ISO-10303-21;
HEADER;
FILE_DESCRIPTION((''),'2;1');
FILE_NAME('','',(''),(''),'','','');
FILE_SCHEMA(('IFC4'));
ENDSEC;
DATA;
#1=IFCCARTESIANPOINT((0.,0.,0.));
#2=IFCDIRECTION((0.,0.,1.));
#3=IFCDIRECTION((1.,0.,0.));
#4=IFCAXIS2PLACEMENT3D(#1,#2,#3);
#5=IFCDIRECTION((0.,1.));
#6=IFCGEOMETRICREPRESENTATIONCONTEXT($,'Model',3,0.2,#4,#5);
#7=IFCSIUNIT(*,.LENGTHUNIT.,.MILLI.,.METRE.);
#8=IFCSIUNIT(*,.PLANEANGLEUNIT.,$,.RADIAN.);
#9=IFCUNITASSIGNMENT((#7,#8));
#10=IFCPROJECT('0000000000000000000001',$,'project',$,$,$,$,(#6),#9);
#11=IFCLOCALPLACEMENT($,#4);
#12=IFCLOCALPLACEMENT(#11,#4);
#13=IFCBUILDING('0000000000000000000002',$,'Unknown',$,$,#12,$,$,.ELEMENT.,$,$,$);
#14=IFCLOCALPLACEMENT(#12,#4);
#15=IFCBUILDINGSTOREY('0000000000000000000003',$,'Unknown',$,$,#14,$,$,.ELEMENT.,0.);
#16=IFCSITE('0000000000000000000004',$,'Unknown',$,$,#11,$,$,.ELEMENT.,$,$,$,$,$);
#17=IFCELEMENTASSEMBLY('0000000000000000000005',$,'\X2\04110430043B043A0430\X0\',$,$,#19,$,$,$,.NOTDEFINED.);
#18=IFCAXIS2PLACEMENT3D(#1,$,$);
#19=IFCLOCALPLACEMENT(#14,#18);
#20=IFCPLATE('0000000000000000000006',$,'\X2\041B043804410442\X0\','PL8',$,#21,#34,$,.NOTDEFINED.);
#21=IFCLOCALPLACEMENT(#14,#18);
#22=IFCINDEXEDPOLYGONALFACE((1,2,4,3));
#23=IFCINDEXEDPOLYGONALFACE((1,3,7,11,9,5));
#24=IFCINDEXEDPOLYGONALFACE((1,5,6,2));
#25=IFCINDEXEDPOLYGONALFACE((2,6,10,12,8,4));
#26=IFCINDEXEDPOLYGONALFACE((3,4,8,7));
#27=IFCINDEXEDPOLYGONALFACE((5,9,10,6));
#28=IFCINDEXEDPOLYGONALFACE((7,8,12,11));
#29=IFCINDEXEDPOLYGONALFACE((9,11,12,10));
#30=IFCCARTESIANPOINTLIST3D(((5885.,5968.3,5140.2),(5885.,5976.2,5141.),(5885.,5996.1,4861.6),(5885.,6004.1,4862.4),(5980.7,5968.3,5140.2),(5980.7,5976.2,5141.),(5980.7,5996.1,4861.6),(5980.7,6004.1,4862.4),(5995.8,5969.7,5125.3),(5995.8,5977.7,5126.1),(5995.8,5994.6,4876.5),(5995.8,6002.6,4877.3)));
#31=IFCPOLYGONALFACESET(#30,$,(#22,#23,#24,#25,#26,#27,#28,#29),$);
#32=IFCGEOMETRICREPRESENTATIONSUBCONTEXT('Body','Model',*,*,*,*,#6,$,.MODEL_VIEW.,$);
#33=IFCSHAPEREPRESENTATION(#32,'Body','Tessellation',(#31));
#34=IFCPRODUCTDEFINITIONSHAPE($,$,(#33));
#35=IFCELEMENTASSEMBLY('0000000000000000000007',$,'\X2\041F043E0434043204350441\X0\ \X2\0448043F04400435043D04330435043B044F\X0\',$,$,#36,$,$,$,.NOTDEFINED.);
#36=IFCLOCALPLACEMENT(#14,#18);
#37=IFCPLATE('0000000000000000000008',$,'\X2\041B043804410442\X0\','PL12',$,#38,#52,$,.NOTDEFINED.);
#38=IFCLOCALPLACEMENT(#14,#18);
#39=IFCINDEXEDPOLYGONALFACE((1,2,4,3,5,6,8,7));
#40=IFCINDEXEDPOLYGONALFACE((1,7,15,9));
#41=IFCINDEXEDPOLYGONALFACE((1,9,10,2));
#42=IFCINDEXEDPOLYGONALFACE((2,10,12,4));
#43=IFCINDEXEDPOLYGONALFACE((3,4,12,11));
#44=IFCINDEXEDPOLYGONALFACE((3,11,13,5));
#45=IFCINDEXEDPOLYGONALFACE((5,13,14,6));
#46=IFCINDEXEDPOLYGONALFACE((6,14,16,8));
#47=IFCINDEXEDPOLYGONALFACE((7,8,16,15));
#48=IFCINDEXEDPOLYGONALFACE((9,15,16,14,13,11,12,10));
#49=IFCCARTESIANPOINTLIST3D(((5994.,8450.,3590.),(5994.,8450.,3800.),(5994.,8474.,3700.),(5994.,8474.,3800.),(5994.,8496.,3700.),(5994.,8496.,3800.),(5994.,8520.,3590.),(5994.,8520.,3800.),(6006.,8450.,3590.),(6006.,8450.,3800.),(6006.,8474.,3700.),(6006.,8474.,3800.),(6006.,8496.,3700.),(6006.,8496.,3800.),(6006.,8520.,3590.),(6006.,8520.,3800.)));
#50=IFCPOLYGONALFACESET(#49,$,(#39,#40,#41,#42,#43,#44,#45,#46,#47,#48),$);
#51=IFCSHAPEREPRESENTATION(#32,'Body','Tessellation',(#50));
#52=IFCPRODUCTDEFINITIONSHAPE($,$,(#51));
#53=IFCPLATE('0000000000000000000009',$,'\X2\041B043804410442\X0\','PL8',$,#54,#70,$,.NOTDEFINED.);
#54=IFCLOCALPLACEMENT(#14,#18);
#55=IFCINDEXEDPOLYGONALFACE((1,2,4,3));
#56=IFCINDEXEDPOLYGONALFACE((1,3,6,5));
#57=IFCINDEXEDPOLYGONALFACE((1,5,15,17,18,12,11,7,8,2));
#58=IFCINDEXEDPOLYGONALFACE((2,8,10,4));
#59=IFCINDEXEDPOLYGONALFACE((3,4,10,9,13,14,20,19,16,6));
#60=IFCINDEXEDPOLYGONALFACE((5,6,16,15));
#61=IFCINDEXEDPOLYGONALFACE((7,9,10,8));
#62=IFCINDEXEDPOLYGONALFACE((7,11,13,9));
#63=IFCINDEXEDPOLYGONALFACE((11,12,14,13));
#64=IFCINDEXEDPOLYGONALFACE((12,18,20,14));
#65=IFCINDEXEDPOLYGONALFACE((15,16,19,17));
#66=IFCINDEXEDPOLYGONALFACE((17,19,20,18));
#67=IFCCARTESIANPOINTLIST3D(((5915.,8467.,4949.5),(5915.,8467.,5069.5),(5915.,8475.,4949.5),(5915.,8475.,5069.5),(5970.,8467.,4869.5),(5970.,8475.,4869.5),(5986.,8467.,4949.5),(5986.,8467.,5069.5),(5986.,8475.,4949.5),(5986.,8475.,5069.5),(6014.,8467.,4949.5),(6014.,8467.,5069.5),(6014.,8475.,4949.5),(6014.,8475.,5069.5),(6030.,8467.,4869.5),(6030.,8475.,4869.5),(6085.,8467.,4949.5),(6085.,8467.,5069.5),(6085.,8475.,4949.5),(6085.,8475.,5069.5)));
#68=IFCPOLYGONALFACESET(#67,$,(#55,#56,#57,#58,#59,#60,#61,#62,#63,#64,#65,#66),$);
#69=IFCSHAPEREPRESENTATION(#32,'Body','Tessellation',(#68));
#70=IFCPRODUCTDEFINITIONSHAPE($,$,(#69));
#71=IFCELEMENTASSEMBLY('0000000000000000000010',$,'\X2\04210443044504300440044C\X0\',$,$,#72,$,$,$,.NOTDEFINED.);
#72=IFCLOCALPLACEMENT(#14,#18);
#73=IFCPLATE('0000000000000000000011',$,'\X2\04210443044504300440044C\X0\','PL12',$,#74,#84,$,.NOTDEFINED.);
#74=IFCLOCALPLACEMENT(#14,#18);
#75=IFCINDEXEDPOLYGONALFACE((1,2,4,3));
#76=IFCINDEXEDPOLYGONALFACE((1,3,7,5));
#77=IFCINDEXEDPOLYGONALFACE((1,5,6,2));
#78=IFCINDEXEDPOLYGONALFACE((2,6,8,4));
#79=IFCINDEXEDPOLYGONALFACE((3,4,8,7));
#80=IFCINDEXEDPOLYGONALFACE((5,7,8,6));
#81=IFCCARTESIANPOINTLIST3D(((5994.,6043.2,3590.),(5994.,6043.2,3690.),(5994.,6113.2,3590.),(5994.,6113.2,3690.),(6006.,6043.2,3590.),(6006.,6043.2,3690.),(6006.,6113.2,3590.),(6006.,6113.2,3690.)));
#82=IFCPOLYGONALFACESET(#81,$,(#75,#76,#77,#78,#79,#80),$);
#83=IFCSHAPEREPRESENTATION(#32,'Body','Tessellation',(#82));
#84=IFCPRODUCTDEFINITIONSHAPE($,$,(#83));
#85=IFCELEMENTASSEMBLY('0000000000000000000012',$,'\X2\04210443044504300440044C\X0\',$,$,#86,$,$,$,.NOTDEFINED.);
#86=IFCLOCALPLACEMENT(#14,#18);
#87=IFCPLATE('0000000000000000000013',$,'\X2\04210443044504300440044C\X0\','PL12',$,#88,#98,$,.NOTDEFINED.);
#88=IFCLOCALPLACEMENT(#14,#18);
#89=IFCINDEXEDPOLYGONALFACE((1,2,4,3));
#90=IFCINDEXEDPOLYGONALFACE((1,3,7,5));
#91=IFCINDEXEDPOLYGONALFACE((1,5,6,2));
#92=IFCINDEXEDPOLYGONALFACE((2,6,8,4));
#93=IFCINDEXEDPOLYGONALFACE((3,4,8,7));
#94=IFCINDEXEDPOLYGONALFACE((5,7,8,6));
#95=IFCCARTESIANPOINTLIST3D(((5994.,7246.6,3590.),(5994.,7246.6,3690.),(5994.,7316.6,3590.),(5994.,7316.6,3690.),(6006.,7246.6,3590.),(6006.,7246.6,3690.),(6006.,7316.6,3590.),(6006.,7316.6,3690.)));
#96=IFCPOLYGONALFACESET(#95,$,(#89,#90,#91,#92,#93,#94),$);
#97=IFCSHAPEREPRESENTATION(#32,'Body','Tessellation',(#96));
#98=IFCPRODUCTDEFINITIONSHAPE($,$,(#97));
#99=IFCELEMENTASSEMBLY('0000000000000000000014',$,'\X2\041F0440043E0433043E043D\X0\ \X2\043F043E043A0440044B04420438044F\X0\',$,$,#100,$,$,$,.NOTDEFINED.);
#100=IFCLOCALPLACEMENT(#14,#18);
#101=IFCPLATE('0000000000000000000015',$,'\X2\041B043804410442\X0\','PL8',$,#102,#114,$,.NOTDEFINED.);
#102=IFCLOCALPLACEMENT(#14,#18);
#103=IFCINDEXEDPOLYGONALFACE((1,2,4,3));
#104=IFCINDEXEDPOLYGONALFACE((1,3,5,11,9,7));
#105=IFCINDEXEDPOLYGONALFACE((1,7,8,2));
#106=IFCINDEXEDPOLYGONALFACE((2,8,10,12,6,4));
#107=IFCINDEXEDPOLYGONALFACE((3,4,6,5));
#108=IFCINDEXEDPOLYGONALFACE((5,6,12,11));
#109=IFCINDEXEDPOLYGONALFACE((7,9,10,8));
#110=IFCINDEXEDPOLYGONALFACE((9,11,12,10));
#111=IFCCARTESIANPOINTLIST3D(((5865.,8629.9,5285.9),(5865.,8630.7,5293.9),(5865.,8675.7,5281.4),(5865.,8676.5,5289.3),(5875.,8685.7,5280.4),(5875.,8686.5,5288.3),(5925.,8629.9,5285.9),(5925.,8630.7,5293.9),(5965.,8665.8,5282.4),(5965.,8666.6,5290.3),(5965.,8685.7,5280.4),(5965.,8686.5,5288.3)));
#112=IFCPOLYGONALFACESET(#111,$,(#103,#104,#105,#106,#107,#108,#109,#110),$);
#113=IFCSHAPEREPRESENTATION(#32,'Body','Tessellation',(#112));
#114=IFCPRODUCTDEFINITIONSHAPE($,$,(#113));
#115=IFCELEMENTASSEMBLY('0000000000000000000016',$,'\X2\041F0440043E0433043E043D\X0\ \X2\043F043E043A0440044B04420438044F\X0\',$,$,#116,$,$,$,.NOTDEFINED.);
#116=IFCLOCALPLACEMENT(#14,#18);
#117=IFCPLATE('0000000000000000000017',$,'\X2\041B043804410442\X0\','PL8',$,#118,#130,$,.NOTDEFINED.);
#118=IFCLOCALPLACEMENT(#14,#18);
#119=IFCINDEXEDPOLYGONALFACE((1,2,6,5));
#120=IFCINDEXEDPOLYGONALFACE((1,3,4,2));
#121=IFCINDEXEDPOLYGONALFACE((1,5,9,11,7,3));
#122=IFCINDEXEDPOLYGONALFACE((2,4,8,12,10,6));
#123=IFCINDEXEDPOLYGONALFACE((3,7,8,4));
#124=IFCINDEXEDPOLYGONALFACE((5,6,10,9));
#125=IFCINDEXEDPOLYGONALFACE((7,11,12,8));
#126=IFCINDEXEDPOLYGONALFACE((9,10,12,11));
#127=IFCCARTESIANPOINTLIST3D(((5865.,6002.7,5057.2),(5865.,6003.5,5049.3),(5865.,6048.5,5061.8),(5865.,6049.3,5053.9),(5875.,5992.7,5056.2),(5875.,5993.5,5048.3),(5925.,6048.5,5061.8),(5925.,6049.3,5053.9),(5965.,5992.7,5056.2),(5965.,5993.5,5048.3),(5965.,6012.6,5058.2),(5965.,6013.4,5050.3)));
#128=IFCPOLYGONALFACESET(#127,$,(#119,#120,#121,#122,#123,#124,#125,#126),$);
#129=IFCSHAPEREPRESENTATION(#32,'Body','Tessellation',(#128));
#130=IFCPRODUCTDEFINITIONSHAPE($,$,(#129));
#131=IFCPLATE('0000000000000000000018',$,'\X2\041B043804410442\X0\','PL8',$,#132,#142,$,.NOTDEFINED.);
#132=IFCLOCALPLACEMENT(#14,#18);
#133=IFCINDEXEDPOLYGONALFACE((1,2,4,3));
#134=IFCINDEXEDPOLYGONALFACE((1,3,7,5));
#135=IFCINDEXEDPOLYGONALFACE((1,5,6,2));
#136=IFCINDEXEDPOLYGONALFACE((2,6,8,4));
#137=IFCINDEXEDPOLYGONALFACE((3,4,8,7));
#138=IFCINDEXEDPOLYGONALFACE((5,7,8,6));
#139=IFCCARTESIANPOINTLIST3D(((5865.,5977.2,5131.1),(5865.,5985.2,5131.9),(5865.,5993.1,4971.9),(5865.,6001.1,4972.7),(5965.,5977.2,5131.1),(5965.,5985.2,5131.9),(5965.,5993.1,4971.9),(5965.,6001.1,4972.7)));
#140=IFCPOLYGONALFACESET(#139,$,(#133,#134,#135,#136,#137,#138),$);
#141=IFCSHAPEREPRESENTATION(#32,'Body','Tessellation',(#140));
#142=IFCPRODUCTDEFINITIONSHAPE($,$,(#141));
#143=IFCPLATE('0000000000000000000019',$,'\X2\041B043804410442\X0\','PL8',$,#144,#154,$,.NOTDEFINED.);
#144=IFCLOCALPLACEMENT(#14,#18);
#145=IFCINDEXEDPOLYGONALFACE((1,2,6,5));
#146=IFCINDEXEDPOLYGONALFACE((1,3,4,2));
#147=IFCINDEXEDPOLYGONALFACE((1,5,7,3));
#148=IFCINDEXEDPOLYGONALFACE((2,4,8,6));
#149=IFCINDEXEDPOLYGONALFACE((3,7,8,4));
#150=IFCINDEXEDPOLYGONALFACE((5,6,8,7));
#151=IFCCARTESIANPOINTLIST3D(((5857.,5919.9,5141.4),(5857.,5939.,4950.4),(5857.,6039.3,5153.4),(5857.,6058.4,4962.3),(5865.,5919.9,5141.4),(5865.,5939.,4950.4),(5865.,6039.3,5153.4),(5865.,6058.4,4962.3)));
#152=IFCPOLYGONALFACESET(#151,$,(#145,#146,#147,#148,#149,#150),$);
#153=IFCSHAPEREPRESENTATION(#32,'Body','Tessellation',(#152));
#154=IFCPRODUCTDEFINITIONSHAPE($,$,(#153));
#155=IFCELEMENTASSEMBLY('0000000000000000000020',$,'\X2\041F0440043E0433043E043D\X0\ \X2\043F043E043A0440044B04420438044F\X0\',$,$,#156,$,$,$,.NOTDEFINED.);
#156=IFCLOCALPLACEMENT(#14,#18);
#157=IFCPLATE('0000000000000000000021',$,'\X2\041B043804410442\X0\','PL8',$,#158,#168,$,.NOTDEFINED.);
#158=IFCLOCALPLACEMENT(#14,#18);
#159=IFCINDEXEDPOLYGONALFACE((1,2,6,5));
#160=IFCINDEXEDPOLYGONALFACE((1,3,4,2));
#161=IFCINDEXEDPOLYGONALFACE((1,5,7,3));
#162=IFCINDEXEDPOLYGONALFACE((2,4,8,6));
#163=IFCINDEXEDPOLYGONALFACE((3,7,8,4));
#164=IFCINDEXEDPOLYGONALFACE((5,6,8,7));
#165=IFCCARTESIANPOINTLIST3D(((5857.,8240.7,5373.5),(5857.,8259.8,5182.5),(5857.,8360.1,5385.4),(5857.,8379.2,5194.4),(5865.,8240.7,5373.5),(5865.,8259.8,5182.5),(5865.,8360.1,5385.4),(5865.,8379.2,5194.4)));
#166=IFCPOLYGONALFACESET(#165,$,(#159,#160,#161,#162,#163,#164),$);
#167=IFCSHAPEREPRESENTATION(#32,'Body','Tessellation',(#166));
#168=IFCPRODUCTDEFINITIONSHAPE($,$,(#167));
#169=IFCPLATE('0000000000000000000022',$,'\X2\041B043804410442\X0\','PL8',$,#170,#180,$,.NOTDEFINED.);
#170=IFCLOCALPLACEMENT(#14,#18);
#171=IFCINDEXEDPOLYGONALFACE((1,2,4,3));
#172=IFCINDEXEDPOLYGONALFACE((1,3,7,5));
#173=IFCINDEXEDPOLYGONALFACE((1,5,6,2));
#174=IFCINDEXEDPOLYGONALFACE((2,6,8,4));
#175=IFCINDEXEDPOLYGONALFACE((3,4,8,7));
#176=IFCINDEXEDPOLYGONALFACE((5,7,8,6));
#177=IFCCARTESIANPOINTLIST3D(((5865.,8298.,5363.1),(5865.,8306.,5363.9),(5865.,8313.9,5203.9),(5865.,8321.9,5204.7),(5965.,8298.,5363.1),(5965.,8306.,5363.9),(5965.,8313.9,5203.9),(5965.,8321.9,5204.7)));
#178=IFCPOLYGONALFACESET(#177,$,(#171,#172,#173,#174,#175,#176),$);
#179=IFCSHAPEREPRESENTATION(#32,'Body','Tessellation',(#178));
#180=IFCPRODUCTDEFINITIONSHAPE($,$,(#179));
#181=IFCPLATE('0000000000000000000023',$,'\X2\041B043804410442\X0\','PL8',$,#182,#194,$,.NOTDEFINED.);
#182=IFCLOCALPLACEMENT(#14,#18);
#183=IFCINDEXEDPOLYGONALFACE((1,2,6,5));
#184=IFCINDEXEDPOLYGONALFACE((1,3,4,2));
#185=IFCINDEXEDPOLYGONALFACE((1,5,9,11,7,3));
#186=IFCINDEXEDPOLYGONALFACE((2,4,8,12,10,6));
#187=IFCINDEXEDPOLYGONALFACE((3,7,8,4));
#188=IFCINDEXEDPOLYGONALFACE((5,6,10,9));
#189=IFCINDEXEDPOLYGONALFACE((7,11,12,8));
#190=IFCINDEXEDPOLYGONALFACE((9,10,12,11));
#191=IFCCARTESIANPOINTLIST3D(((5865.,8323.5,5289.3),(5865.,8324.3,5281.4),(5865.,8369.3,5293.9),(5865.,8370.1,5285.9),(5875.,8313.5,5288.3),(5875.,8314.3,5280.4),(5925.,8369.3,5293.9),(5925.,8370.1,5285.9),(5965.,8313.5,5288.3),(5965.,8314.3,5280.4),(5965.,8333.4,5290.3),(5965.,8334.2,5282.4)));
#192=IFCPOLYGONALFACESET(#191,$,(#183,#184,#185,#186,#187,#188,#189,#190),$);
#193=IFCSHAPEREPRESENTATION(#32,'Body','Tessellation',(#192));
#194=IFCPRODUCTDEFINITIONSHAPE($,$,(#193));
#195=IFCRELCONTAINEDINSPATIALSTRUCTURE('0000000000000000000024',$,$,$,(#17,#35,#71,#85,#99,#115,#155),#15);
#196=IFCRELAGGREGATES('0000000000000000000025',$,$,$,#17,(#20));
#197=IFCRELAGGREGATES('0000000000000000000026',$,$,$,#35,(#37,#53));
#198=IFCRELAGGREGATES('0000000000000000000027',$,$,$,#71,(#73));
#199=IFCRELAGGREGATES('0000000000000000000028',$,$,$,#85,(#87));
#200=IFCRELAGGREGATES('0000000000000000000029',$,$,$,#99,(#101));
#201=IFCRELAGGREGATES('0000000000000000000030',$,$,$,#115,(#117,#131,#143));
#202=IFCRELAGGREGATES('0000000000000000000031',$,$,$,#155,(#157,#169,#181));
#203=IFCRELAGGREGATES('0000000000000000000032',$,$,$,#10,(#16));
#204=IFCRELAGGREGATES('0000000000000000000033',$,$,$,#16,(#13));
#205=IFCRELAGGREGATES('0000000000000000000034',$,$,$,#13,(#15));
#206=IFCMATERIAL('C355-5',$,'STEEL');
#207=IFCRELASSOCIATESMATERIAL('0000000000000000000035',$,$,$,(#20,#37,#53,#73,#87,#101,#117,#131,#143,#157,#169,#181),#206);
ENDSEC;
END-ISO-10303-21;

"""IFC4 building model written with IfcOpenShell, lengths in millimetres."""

from ifc_helpers import new_model, si_unit, direction, frame, origin_with_axes, place, context, subcontext, project, spatial, line, indexed_curve, outline, extrude, material, element, aggregate, save


model = new_model("IFC4")

# Units and contexts
model_context = context("Model", 3, precision=0.2, world=origin_with_axes(), true_north=direction((0.0, 1.0)))
body_context = subcontext(model_context, "Body", "Model", "MODEL_VIEW")
ifc_project = project(units=[si_unit("LENGTHUNIT", "METRE", prefix="MILLI"), si_unit("PLANEANGLEUNIT", "RADIAN")], contexts=[model_context])

# Site, building, storey
site_placement = place(None, origin_with_axes())
site = spatial("IfcSite", under=ifc_project, at=site_placement, Name="Unknown", CompositionType="ELEMENT")
building_placement = place(site_placement, origin_with_axes())
building = spatial("IfcBuilding", under=site, at=building_placement, Name="Unknown", CompositionType="ELEMENT")
storey_placement = place(building_placement, origin_with_axes())
storey = spatial("IfcBuildingStorey", under=building, at=storey_placement, Name="Unknown", CompositionType="ELEMENT", Elevation=0.0)

# Element assembly
ifc_material_1 = material(Name="C355-5", Category="STEEL")
assembly_1_placement = place(storey_placement, frame((6000.0, 346.0, 4437.3), z_axis=(1.0, 0.0, 0.0), x_axis=(0.0, 0.995037, 0.099504)))
assembly_1 = element("IfcElementAssembly", 1, at=assembly_1_placement, inside=storey, Name="Балка", PredefinedType="NOTDEFINED")

# Plate
plate_1_placement = place(assembly_1_placement, frame((5668.3, 140.0, -115.0), z_axis=(1.0, 0.0, 0.0), x_axis=(0.0, 0.0, 1.0)))
plate_1 = element("IfcPlate", 2, at=plate_1_placement, material=ifc_material_1, Name="Лист", Description="PL8", PredefinedType="NOTDEFINED", context=body_context, shape_type="SolidModel", body=[
    extrude(outline(indexed_curve([(0.0, 0.0), (95.8, 0.0), (110.8, 15.0), (110.8, 265.0), (95.8, 280.0), (0.0, 280.0)], segments=[line(1, 2, 3, 4, 5, 6, 1)])), frame((0.0, 0.0, 4.0), z_axis=(0.0, 0.0, 1.0), x_axis=(1.0, 0.0, 0.0)), (0.0, 0.0, -1.0), 8.0),
])
aggregate(assembly_1, [plate_1])

# Element assembly, plates
assembly_2_placement = place(storey_placement, frame((6000.0, 8485.0, 5252.7), z_axis=(-1.0, 0.0, 0.0), x_axis=(0.0, 0.0, -1.0)))
assembly_2 = element("IfcElementAssembly", 3, at=assembly_2_placement, inside=storey, Name="Подвес шпренгеля", PredefinedType="NOTDEFINED")
plate_2_placement = place(assembly_2_placement, frame((1662.7, 35.0, 0.0), z_axis=(0.0, 0.0, -1.0), x_axis=(0.0, -1.0, 0.0)))
plate_2 = element("IfcPlate", 4, at=plate_2_placement, material=ifc_material_1, Name="Лист", Description="PL12", PredefinedType="NOTDEFINED", context=body_context, shape_type="SolidModel", body=[
    extrude(outline(indexed_curve([(0.0, 0.0), (70.0, 0.0), (70.0, 210.0), (46.0, 210.0), (46.0, 110.0), (24.0, 110.0), (24.0, 210.0), (0.0, 210.0)], segments=[line(1, 2, 3, 4, 5, 6, 7, 8, 1)])), frame((0.0, 0.0, 6.0), z_axis=(0.0, 0.0, 1.0), x_axis=(1.0, 0.0, 0.0)), (0.0, 0.0, -1.0), 12.0),
])
plate_3_placement = place(assembly_2_placement, frame((183.2, 14.0, 85.0), z_axis=(0.0, -1.0, 0.0), x_axis=(0.0, 0.0, -1.0)))
plate_3 = element("IfcPlate", 5, at=plate_3_placement, material=ifc_material_1, Name="Лист", Description="PL8", PredefinedType="NOTDEFINED", context=body_context, shape_type="SolidModel", body=[
    extrude(outline(indexed_curve([(0.0, 0.0), (71.0, 0.0), (71.0, 120.0), (99.0, 120.0), (99.0, 0.0), (170.0, 0.0), (170.0, 120.0), (115.0, 200.0), (55.0, 200.0), (0.0, 120.0)], segments=[line(1, 2, 3, 4, 5, 6, 7, 8, 9, 10, 1)])), frame((0.0, 0.0, 4.0), z_axis=(0.0, 0.0, 1.0), x_axis=(1.0, 0.0, 0.0)), (0.0, 0.0, -1.0), 8.0),
])
aggregate(assembly_2, [plate_2, plate_3])

# Element assemblies, plates
assembly_3_placement = place(storey_placement, frame((6000.0, 6043.2, 3690.0), z_axis=(-1.0, 0.0, 0.0), x_axis=(0.0, 1.0, 0.0)))
assembly_3 = element("IfcElementAssembly", 6, at=assembly_3_placement, inside=storey, Name="Сухарь", PredefinedType="NOTDEFINED")
plate_4_placement = place(assembly_3_placement, origin_with_axes())
plate_4 = element("IfcPlate", 7, at=plate_4_placement, material=ifc_material_1, Name="Сухарь", Description="PL12", PredefinedType="NOTDEFINED", context=body_context, shape_type="SolidModel", body=[
    extrude(outline(indexed_curve([(0.0, 0.0), (70.0, 0.0), (70.0, 100.0), (0.0, 100.0)], segments=[line(1, 2, 3, 4, 1)])), frame((0.0, 0.0, 6.0), z_axis=(0.0, 0.0, 1.0), x_axis=(1.0, 0.0, 0.0)), (0.0, 0.0, -1.0), 12.0),
])
aggregate(assembly_3, [plate_4])
assembly_4_placement = place(storey_placement, frame((6000.0, 7246.6, 3690.0), z_axis=(-1.0, 0.0, 0.0), x_axis=(0.0, 1.0, 0.0)))
assembly_4 = element("IfcElementAssembly", 8, at=assembly_4_placement, inside=storey, Name="Сухарь", PredefinedType="NOTDEFINED")
plate_5_placement = place(assembly_4_placement, origin_with_axes())
plate_5 = element("IfcPlate", 9, at=plate_5_placement, material=ifc_material_1, Name="Сухарь", Description="PL12", PredefinedType="NOTDEFINED", context=body_context, shape_type="SolidModel", body=[
    extrude(outline(indexed_curve([(0.0, 0.0), (70.0, 0.0), (70.0, 100.0), (0.0, 100.0)], segments=[line(1, 2, 3, 4, 1)])), frame((0.0, 0.0, 6.0), z_axis=(0.0, 0.0, 1.0), x_axis=(1.0, 0.0, 0.0)), (0.0, 0.0, -1.0), 12.0),
])
aggregate(assembly_4, [plate_5])
assembly_5_placement = place(storey_placement, frame((6000.0, 8690.0, 5283.9), z_axis=(0.0, -0.995037, 0.099504), x_axis=(-1.0, 0.0, 0.0)))
assembly_5 = element("IfcElementAssembly", 10, at=assembly_5_placement, inside=storey, Name="Прогон покрытия", PredefinedType="NOTDEFINED")
plate_6_placement = place(assembly_5_placement, frame((35.0, 0.0, 60.0), z_axis=(0.0, -1.0, 0.0), x_axis=(0.0, 0.0, -1.0)))
plate_6 = element("IfcPlate", 11, at=plate_6_placement, material=ifc_material_1, Name="Лист", Description="PL8", PredefinedType="NOTDEFINED", context=body_context, shape_type="SolidModel", body=[
    extrude(outline(indexed_curve([(0.0, 40.0), (36.0, 0.0), (56.0, 0.0), (56.0, 90.0), (46.0, 100.0), (0.0, 100.0)], segments=[line(1, 2, 3, 4, 5, 6, 1)])), frame((0.0, 0.0, 4.0), z_axis=(0.0, 0.0, 1.0), x_axis=(1.0, 0.0, 0.0)), (0.0, 0.0, -1.0), 8.0),
])
aggregate(assembly_5, [plate_6])

# Element assemblies, plates
assembly_6_placement = place(storey_placement, frame((0.0, 5989.2, 5051.9), z_axis=(0.0, 0.995037, 0.099504), x_axis=(1.0, 0.0, 0.0)))
assembly_6 = element("IfcElementAssembly", 12, at=assembly_6_placement, inside=storey, Name="Прогон покрытия", PredefinedType="NOTDEFINED")
plate_7_placement = place(assembly_6_placement, frame((5965.0, 0.0, 60.0), z_axis=(0.0, 1.0, 0.0), x_axis=(0.0, 0.0, -1.0)))
plate_7 = element("IfcPlate", 13, at=plate_7_placement, material=ifc_material_1, Name="Лист", Description="PL8", PredefinedType="NOTDEFINED", context=body_context, shape_type="SolidModel", body=[
    extrude(outline(indexed_curve([(0.0, 40.0), (36.0, 0.0), (56.0, 0.0), (56.0, 90.0), (46.0, 100.0), (0.0, 100.0)], segments=[line(1, 2, 3, 4, 5, 6, 1)])), frame((0.0, 0.0, 4.0), z_axis=(0.0, 0.0, 1.0), x_axis=(1.0, 0.0, 0.0)), (0.0, 0.0, -1.0), 8.0),
])
plate_8_placement = place(assembly_6_placement, frame((5965.0, 80.0, 0.0), z_axis=(0.0, 0.0, -1.0), x_axis=(0.0, -1.0, 0.0)))
plate_8 = element("IfcPlate", 14, at=plate_8_placement, material=ifc_material_1, Name="Лист", Description="PL8", PredefinedType="NOTDEFINED", context=body_context, shape_type="SolidModel", body=[
    extrude(outline(indexed_curve([(0.0, 0.0), (160.0, 0.0), (160.0, 100.0), (0.0, 100.0)], segments=[line(1, 2, 3, 4, 1)])), frame((0.0, 0.0, 4.0), z_axis=(0.0, 0.0, 1.0), x_axis=(1.0, 0.0, 0.0)), (0.0, 0.0, -1.0), 8.0),
])
plate_9_placement = place(assembly_6_placement, frame((5861.0, 96.0, -60.0), z_axis=(1.0, 0.0, 0.0), x_axis=(0.0, 0.0, 1.0)))
plate_9 = element("IfcPlate", 15, at=plate_9_placement, material=ifc_material_1, Name="Лист", Description="PL8", PredefinedType="NOTDEFINED", context=body_context, shape_type="SolidModel", body=[
    extrude(outline(indexed_curve([(0.0, 0.0), (120.0, 0.0), (120.0, 192.0), (0.0, 192.0)], segments=[line(1, 2, 3, 4, 1)])), frame((0.0, 0.0, 4.0), z_axis=(0.0, 0.0, 1.0), x_axis=(1.0, 0.0, 0.0)), (0.0, 0.0, -1.0), 8.0),
])
aggregate(assembly_6, [plate_7, plate_8, plate_9])
assembly_7_placement = place(storey_placement, frame((0.0, 8310.0, 5283.9), z_axis=(0.0, 0.995037, 0.099504), x_axis=(1.0, 0.0, 0.0)))
assembly_7 = element("IfcElementAssembly", 16, at=assembly_7_placement, inside=storey, Name="Прогон покрытия", PredefinedType="NOTDEFINED")
plate_10_placement = place(assembly_7_placement, frame((5861.0, 96.0, -60.0), z_axis=(1.0, 0.0, 0.0), x_axis=(0.0, 0.0, 1.0)))
plate_10 = element("IfcPlate", 17, at=plate_10_placement, material=ifc_material_1, Name="Лист", Description="PL8", PredefinedType="NOTDEFINED", context=body_context, shape_type="SolidModel", body=[
    extrude(outline(indexed_curve([(0.0, 0.0), (120.0, 0.0), (120.0, 192.0), (0.0, 192.0)], segments=[line(1, 2, 3, 4, 1)])), frame((0.0, 0.0, 4.0), z_axis=(0.0, 0.0, 1.0), x_axis=(1.0, 0.0, 0.0)), (0.0, 0.0, -1.0), 8.0),
])
plate_11_placement = place(assembly_7_placement, frame((5965.0, 80.0, 0.0), z_axis=(0.0, 0.0, -1.0), x_axis=(0.0, -1.0, 0.0)))
plate_11 = element("IfcPlate", 18, at=plate_11_placement, material=ifc_material_1, Name="Лист", Description="PL8", PredefinedType="NOTDEFINED", context=body_context, shape_type="SolidModel", body=[
    extrude(outline(indexed_curve([(0.0, 0.0), (160.0, 0.0), (160.0, 100.0), (0.0, 100.0)], segments=[line(1, 2, 3, 4, 1)])), frame((0.0, 0.0, 4.0), z_axis=(0.0, 0.0, 1.0), x_axis=(1.0, 0.0, 0.0)), (0.0, 0.0, -1.0), 8.0),
])
plate_12_placement = place(assembly_7_placement, frame((5965.0, 0.0, 60.0), z_axis=(0.0, 1.0, 0.0), x_axis=(0.0, 0.0, -1.0)))
plate_12 = element("IfcPlate", 19, at=plate_12_placement, material=ifc_material_1, Name="Лист", Description="PL8", PredefinedType="NOTDEFINED", context=body_context, shape_type="SolidModel", body=[
    extrude(outline(indexed_curve([(0.0, 40.0), (36.0, 0.0), (56.0, 0.0), (56.0, 90.0), (46.0, 100.0), (0.0, 100.0)], segments=[line(1, 2, 3, 4, 5, 6, 1)])), frame((0.0, 0.0, 4.0), z_axis=(0.0, 0.0, 1.0), x_axis=(1.0, 0.0, 0.0)), (0.0, 0.0, -1.0), 8.0),
])
aggregate(assembly_7, [plate_10, plate_11, plate_12])

save(model, "model.ifc")
